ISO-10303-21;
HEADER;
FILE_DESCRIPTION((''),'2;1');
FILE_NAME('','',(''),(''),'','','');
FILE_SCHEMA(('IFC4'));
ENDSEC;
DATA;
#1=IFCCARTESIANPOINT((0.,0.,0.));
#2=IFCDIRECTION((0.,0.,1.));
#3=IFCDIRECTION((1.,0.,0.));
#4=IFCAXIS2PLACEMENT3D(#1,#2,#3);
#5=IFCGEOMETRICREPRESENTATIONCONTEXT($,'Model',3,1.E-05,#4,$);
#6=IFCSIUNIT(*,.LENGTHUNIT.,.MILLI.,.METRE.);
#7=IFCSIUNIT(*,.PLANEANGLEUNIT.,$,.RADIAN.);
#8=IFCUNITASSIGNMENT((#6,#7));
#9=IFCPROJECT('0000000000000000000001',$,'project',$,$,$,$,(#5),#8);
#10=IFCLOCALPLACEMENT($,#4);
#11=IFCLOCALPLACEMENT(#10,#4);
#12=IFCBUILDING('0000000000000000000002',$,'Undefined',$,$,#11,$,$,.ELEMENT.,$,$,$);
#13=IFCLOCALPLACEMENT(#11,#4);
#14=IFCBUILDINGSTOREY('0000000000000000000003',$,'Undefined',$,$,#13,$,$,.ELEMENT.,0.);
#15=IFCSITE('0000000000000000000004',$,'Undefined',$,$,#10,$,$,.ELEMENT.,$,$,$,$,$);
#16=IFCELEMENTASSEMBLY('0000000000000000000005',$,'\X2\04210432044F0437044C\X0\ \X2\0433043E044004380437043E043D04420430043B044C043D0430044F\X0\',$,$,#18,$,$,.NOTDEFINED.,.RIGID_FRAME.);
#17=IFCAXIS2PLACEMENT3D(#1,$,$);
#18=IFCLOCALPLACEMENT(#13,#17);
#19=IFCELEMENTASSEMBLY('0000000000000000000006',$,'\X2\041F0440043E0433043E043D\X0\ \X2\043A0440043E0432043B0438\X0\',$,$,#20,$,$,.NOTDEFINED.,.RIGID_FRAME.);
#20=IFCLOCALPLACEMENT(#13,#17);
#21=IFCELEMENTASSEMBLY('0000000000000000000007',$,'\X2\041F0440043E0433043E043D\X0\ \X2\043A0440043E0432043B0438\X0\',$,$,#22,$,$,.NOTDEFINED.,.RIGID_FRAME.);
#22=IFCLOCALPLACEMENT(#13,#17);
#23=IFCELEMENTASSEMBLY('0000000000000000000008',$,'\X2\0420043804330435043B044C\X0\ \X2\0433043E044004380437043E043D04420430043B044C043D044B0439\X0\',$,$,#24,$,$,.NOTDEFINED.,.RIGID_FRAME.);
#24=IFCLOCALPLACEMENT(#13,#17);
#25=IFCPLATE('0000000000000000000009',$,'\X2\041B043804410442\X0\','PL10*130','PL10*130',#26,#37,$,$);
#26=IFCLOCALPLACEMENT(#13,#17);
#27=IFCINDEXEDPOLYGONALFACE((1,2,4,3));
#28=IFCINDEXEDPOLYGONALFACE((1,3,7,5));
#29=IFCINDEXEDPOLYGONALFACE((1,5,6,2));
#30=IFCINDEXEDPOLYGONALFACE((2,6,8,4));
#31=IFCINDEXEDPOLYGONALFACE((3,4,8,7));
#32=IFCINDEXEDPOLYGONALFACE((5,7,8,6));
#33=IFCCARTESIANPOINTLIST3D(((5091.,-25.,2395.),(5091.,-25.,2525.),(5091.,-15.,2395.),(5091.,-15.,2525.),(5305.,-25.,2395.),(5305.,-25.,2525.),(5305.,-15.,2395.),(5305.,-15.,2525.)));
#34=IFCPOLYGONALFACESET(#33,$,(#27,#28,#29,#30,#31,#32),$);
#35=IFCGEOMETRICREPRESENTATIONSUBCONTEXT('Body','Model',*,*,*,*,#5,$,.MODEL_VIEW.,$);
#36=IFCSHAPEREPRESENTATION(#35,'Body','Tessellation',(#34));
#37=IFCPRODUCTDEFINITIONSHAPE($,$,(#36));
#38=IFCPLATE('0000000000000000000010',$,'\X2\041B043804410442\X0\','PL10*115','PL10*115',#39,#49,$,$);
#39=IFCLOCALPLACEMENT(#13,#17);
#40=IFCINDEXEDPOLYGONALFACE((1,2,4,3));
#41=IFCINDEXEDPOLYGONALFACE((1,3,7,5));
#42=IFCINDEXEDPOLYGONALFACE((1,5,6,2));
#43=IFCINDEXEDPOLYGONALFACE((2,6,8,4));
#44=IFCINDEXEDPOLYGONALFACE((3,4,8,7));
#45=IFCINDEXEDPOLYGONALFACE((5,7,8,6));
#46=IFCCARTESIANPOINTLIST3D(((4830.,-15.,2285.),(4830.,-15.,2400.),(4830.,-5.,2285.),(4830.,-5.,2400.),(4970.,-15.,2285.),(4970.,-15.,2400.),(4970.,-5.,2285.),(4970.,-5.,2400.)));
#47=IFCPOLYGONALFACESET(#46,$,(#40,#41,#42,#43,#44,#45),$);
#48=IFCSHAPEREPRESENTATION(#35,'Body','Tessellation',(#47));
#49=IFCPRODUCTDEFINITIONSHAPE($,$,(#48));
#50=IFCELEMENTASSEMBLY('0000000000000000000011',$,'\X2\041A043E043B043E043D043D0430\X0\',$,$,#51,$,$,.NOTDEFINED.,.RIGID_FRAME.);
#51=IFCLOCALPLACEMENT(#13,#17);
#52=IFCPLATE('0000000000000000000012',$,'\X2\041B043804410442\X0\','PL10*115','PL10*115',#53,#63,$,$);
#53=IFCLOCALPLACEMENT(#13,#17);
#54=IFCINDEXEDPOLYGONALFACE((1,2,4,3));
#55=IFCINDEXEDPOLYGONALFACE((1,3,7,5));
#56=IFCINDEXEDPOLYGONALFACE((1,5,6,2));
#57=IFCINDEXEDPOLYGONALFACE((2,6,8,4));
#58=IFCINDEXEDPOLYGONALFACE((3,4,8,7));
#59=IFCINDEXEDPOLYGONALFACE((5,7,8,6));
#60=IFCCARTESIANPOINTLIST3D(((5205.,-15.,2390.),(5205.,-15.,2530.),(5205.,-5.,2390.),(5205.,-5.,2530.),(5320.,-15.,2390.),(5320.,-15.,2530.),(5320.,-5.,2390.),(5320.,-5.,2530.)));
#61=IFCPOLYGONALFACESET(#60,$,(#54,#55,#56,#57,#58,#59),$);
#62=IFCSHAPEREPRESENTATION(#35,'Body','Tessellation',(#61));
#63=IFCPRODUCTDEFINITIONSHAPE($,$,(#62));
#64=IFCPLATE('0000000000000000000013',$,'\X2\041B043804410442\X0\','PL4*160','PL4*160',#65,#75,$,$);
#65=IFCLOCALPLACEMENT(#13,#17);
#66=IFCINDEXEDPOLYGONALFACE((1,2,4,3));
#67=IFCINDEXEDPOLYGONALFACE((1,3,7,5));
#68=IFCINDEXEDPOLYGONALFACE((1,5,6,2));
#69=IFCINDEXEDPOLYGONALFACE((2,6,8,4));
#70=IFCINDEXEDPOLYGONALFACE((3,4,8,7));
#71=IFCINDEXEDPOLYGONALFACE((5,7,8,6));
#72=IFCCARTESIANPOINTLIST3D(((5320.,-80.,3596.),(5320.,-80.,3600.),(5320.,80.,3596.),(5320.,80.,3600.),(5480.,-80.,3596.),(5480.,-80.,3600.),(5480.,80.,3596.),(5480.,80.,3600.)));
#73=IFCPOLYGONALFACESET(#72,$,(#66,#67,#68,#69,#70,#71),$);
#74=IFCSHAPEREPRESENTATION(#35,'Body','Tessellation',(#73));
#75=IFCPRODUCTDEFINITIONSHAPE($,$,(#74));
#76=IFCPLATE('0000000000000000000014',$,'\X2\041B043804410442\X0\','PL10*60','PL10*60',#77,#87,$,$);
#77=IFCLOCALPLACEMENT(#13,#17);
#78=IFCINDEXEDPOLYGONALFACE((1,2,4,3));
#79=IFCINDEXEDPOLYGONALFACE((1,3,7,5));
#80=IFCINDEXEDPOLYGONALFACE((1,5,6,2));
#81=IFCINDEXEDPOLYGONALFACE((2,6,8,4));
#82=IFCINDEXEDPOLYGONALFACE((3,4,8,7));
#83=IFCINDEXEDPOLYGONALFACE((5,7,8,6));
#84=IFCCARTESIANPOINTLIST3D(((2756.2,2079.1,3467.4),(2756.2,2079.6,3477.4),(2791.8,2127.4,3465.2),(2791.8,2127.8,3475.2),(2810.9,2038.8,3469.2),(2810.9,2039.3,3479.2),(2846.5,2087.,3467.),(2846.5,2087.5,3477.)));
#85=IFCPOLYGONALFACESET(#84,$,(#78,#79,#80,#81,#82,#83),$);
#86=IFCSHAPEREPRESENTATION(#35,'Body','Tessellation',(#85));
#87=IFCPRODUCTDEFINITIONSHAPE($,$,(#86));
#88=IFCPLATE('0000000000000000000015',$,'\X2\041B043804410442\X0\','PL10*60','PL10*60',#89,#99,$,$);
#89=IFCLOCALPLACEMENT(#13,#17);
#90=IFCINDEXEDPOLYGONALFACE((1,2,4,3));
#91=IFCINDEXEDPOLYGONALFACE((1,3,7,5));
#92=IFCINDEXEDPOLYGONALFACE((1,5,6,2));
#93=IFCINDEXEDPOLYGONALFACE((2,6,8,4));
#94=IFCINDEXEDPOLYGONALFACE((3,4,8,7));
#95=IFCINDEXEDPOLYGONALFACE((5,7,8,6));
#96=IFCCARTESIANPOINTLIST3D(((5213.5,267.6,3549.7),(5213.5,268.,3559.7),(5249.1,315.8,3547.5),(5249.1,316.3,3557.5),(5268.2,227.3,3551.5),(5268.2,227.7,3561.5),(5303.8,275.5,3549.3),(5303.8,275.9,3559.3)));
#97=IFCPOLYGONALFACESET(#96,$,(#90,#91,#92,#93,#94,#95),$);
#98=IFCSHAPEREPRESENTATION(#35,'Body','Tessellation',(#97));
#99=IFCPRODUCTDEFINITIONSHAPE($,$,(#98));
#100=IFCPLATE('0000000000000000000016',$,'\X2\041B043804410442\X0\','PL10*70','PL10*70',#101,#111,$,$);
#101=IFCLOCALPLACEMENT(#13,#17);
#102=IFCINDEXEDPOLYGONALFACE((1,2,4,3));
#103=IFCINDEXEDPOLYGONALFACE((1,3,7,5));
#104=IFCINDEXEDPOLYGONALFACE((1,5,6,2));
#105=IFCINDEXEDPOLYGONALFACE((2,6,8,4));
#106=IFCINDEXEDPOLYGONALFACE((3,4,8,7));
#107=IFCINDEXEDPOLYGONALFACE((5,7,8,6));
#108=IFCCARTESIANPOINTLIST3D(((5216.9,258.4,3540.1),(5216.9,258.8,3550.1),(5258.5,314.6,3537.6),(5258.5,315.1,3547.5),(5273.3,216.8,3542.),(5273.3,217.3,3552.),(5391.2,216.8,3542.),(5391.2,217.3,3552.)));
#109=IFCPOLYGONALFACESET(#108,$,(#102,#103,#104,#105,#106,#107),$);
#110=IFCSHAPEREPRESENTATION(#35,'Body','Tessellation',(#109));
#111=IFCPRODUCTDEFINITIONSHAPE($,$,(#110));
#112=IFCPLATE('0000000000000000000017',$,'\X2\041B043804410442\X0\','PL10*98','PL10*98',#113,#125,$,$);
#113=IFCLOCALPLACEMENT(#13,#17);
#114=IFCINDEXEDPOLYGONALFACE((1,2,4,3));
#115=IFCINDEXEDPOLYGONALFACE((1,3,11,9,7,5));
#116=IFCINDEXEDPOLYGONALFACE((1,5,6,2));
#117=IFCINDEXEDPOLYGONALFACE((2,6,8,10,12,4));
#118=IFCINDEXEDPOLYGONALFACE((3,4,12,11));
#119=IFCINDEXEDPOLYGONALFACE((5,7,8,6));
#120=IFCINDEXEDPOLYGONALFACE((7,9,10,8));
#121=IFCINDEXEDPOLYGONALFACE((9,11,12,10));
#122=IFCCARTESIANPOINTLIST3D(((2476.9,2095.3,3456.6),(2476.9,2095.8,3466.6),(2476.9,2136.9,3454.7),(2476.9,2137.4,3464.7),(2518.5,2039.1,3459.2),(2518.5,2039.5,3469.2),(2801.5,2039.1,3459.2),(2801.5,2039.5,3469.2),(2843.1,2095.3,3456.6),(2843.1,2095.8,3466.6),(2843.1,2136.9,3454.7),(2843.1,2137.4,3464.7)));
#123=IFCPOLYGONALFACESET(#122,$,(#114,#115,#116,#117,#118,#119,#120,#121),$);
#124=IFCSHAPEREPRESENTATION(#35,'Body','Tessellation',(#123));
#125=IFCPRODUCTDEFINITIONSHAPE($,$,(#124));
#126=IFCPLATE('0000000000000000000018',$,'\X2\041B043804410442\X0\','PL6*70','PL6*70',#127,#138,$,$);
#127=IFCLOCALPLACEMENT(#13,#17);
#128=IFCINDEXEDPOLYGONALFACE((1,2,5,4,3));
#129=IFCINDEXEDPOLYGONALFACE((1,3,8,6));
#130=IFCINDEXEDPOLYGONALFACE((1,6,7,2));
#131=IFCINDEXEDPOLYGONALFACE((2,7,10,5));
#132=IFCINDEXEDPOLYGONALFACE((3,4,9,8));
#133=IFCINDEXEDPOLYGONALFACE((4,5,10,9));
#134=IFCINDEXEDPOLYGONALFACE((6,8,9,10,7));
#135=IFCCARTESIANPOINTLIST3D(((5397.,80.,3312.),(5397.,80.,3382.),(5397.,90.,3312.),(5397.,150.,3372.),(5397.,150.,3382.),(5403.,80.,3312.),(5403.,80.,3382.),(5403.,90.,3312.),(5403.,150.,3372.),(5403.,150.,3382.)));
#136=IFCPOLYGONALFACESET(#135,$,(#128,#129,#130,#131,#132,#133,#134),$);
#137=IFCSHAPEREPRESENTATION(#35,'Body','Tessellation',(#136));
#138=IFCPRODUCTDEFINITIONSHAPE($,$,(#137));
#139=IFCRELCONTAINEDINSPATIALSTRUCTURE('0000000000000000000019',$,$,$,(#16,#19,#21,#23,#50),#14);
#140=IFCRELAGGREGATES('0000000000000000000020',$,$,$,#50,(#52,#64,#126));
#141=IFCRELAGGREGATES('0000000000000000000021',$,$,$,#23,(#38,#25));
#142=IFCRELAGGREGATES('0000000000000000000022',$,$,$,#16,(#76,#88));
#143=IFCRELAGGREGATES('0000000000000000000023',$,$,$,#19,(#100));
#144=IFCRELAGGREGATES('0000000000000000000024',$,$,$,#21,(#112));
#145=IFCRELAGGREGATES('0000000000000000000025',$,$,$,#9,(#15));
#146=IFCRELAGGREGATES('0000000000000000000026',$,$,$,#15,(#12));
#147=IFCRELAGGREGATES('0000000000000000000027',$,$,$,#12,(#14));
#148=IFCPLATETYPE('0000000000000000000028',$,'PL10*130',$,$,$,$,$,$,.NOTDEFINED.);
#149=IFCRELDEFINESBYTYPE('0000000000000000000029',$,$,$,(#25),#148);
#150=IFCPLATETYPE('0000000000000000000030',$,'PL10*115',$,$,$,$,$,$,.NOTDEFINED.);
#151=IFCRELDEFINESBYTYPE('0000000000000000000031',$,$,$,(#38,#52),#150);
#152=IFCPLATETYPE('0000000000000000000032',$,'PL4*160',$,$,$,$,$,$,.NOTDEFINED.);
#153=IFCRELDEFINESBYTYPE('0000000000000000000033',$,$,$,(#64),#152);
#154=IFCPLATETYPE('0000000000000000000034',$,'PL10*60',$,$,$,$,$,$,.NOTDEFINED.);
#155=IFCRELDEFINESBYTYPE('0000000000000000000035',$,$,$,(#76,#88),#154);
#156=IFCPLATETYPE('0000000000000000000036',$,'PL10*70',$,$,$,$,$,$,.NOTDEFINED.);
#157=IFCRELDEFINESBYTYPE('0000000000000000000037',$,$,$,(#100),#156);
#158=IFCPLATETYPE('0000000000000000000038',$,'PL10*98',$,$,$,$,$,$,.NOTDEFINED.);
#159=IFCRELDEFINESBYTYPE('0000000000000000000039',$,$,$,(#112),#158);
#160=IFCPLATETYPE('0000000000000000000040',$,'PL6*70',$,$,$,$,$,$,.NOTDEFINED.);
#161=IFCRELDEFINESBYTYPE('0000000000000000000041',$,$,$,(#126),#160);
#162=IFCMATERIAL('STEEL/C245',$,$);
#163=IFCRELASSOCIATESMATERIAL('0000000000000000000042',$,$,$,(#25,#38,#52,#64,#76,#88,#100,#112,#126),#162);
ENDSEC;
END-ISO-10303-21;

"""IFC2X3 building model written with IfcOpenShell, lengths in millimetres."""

from ifc_helpers import new_model, si_unit, frame, origin_with_axes, place, context, subcontext, project, spatial, polyline, outline, extrude, material, type_object, element, aggregate, save


model = new_model("IFC2X3")

# Units and contexts
model_context = context("Model", 3, precision=1e-05, world=origin_with_axes())
body_context = subcontext(model_context, "Body", "Model", "MODEL_VIEW")
ifc_project = project(units=[si_unit("LENGTHUNIT", "METRE", prefix="MILLI"), si_unit("PLANEANGLEUNIT", "RADIAN")], contexts=[model_context])

# Site, building, storey
site_placement = place(None, origin_with_axes())
site = spatial("IfcSite", under=ifc_project, at=site_placement, Name="Undefined", CompositionType="ELEMENT")
building_placement = place(site_placement, origin_with_axes())
building = spatial("IfcBuilding", under=site, at=building_placement, Name="Undefined", CompositionType="ELEMENT")
storey_placement = place(building_placement, origin_with_axes())
storey = spatial("IfcBuildingStorey", under=building, at=storey_placement, Name="Undefined", CompositionType="ELEMENT", Elevation=0.0)

# Shared definitions
ifc_material_1 = material(Name="STEEL/C245")

# Element assembly
assembly_1_placement = place(storey_placement, origin_with_axes())
assembly_1 = element("IfcElementAssembly", 1, at=assembly_1_placement, inside=storey, Name="Связь горизонтальная", AssemblyPlace="NOTDEFINED", PredefinedType="RIGID_FRAME")

# Element assemblies
assembly_2_placement = place(storey_placement, origin_with_axes())
assembly_2 = element("IfcElementAssembly", 2, at=assembly_2_placement, inside=storey, Name="Прогон кровли", AssemblyPlace="NOTDEFINED", PredefinedType="RIGID_FRAME")
assembly_3_placement = place(storey_placement, origin_with_axes())
assembly_3 = element("IfcElementAssembly", 3, at=assembly_3_placement, inside=storey, Name="Прогон кровли", AssemblyPlace="NOTDEFINED", PredefinedType="RIGID_FRAME")

# Element assembly
assembly_4_placement = place(storey_placement, origin_with_axes())
assembly_4 = element("IfcElementAssembly", 4, at=assembly_4_placement, inside=storey, Name="Ригель горизонтальный", AssemblyPlace="NOTDEFINED", PredefinedType="RIGID_FRAME")

# Plates
plate_type_1 = type_object("IfcPlateType", Name="PL10*130", PredefinedType="NOTDEFINED")
plate_1_placement = place(assembly_4_placement, frame((5305.0, -20.0, 2460.0), z_axis=(0.0, -1.0, 0.0), x_axis=(-1.0, 0.0, 0.0)))
plate_1 = element("IfcPlate", 5, at=plate_1_placement, type_object=plate_type_1, material=ifc_material_1, Name="Лист", Description="PL10*130", ObjectType="PL10*130", context=body_context, shape_type="SweptSolid", body=[
    extrude(outline(polyline([(214.0, 65.0), (214.0, -65.0), (0.0, -65.0), (0.0, 65.0), (214.0, 65.0)])), frame((0.0, 0.0, -5.0), z_axis=(0.0, 0.0, 1.0), x_axis=(1.0, 0.0, 0.0)), (0.0, 0.0, 1.0), 10.0),
])
plate_type_2 = type_object("IfcPlateType", Name="PL10*115", PredefinedType="NOTDEFINED")
plate_2_placement = place(assembly_4_placement, frame((4830.0, -10.0, 2400.0), z_axis=(0.0, -1.0, 0.0), x_axis=(0.0, 0.0, -1.0)))
plate_2 = element("IfcPlate", 6, at=plate_2_placement, type_object=plate_type_2, material=ifc_material_1, Name="Лист", Description="PL10*115", ObjectType="PL10*115", context=body_context, shape_type="SweptSolid", body=[
    extrude(outline(polyline([(0.0, 0.0), (115.0, 0.0), (115.0, 140.0), (0.0, 140.0), (0.0, 0.0)])), frame((0.0, 0.0, -5.0), z_axis=(0.0, 0.0, 1.0), x_axis=(1.0, 0.0, 0.0)), (0.0, 0.0, 1.0), 10.0),
])

# Element assembly, plates
assembly_5_placement = place(storey_placement, origin_with_axes())
assembly_5 = element("IfcElementAssembly", 7, at=assembly_5_placement, inside=storey, Name="Колонна", AssemblyPlace="NOTDEFINED", PredefinedType="RIGID_FRAME")
plate_3_placement = place(assembly_5_placement, frame((5320.0, -10.0, 2530.0), z_axis=(0.0, -1.0, 0.0), x_axis=(-1.0, 0.0, 0.0)))
plate_3 = element("IfcPlate", 8, at=plate_3_placement, type_object=plate_type_2, material=ifc_material_1, Name="Лист", Description="PL10*115", ObjectType="PL10*115", context=body_context, shape_type="SweptSolid", body=[
    extrude(outline(polyline([(0.0, 0.0), (115.0, 0.0), (115.0, 140.0), (0.0, 140.0), (0.0, 0.0)])), frame((0.0, 0.0, -5.0), z_axis=(0.0, 0.0, 1.0), x_axis=(1.0, 0.0, 0.0)), (0.0, 0.0, 1.0), 10.0),
])
plate_type_3 = type_object("IfcPlateType", Name="PL4*160", PredefinedType="NOTDEFINED")
plate_4_placement = place(assembly_5_placement, frame((5400.0, -80.0, 3598.0), z_axis=(0.0, 0.0, -1.0), x_axis=(0.0, 1.0, 0.0)))
plate_4 = element("IfcPlate", 9, at=plate_4_placement, type_object=plate_type_3, material=ifc_material_1, Name="Лист", Description="PL4*160", ObjectType="PL4*160", context=body_context, shape_type="SweptSolid", body=[
    extrude(outline(polyline([(0.0, -80.0), (0.0, 80.0), (160.0, 80.0), (160.0, -80.0), (0.0, -80.0)])), frame((0.0, 0.0, -2.0), z_axis=(0.0, 0.0, 1.0), x_axis=(1.0, 0.0, 0.0)), (0.0, 0.0, 1.0), 4.0),
])

# Plates
plate_type_4 = type_object("IfcPlateType", Name="PL10*60", PredefinedType="NOTDEFINED")
plate_5_placement = place(assembly_1_placement, frame((2774.0, 2103.5, 3471.3), z_axis=(0.0, -0.045408, -0.998969), x_axis=(0.804616, -0.593183, 0.026963)))
plate_5 = element("IfcPlate", 10, at=plate_5_placement, type_object=plate_type_4, material=ifc_material_1, Name="Лист", Description="PL10*60", ObjectType="PL10*60", context=body_context, shape_type="SweptSolid", body=[
    extrude(outline(polyline([(0.0, 30.0), (68.0, 30.0), (68.0, -30.0), (0.0, -30.0), (0.0, 30.0)])), frame((0.0, 0.0, -5.0), z_axis=(0.0, 0.0, 1.0), x_axis=(1.0, 0.0, 0.0)), (0.0, 0.0, 1.0), 10.0),
])
plate_6_placement = place(assembly_1_placement, frame((5286.0, 251.6, 3555.4), z_axis=(0.0, 0.045408, 0.998969), x_axis=(-0.804616, 0.593183, -0.026963)))
plate_6 = element("IfcPlate", 11, at=plate_6_placement, type_object=plate_type_4, material=ifc_material_1, Name="Лист", Description="PL10*60", ObjectType="PL10*60", context=body_context, shape_type="SweptSolid", body=[
    extrude(outline(polyline([(68.0, 30.0), (68.0, -30.0), (0.0, -30.0), (0.0, 30.0), (68.0, 30.0)])), frame((0.0, 0.0, -5.0), z_axis=(0.0, 0.0, 1.0), x_axis=(1.0, 0.0, 0.0)), (0.0, 0.0, 1.0), 10.0),
])
plate_type_5 = type_object("IfcPlateType", Name="PL10*70", PredefinedType="NOTDEFINED")
plate_7_placement = place(assembly_2_placement, frame((5391.2, 217.0, 3547.0), z_axis=(0.0, 0.045408, 0.998969), x_axis=(-0.804616, 0.593183, -0.026963)))
plate_7 = element("IfcPlate", 12, at=plate_7_placement, type_object=plate_type_5, material=ifc_material_1, Name="Лист", Description="PL10*70", ObjectType="PL10*70", context=body_context, shape_type="SweptSolid", body=[
    extrude(outline(polyline([(0.0, 0.0), (164.9, 0.0), (164.9, 70.0), (94.9, 70.0), (0.0, 0.0)])), frame((0.0, 0.0, -5.0), z_axis=(0.0, 0.0, 1.0), x_axis=(1.0, 0.0, 0.0)), (0.0, 0.0, 1.0), 10.0),
])
plate_type_6 = type_object("IfcPlateType", Name="PL10*98", PredefinedType="NOTDEFINED")
plate_8_placement = place(assembly_3_placement, frame((2843.1, 2137.1, 3459.7), z_axis=(0.0, -0.045408, -0.998969), x_axis=(0.0, -0.998969, 0.045408)))
plate_8 = element("IfcPlate", 13, at=plate_8_placement, type_object=plate_type_6, material=ifc_material_1, Name="Лист", Description="PL10*98", ObjectType="PL10*98", context=body_context, shape_type="SweptSolid", body=[
    extrude(outline(polyline([(0.0, 0.0), (41.6, 0.0), (97.9, 41.6), (97.9, 324.6), (41.6, 366.1), (0.0, 366.1), (0.0, 0.0)])), frame((0.0, 0.0, -5.0), z_axis=(0.0, 0.0, 1.0), x_axis=(1.0, 0.0, 0.0)), (0.0, 0.0, 1.0), 10.0),
])
plate_type_7 = type_object("IfcPlateType", Name="PL6*70", PredefinedType="NOTDEFINED")
plate_9_placement = place(assembly_5_placement, frame((5400.0, 150.0, 3382.0), z_axis=(1.0, 0.0, 0.0), x_axis=(0.0, -1.0, 0.0)))
plate_9 = element("IfcPlate", 14, at=plate_9_placement, type_object=plate_type_7, material=ifc_material_1, Name="Лист", Description="PL6*70", ObjectType="PL6*70", context=body_context, shape_type="SweptSolid", body=[
    extrude(outline(polyline([(0.0, 0.0), (70.0, 0.0), (70.0, 70.0), (60.0, 70.0), (0.0, 10.0), (0.0, 0.0)])), frame((0.0, 0.0, -3.0), z_axis=(0.0, 0.0, 1.0), x_axis=(1.0, 0.0, 0.0)), (0.0, 0.0, 1.0), 6.0),
])
aggregate(assembly_5, [plate_3, plate_4, plate_9])

aggregate(assembly_4, [plate_2, plate_1])
aggregate(assembly_1, [plate_5, plate_6])
aggregate(assembly_2, [plate_7])
aggregate(assembly_3, [plate_8])

save(model, "model.ifc")
